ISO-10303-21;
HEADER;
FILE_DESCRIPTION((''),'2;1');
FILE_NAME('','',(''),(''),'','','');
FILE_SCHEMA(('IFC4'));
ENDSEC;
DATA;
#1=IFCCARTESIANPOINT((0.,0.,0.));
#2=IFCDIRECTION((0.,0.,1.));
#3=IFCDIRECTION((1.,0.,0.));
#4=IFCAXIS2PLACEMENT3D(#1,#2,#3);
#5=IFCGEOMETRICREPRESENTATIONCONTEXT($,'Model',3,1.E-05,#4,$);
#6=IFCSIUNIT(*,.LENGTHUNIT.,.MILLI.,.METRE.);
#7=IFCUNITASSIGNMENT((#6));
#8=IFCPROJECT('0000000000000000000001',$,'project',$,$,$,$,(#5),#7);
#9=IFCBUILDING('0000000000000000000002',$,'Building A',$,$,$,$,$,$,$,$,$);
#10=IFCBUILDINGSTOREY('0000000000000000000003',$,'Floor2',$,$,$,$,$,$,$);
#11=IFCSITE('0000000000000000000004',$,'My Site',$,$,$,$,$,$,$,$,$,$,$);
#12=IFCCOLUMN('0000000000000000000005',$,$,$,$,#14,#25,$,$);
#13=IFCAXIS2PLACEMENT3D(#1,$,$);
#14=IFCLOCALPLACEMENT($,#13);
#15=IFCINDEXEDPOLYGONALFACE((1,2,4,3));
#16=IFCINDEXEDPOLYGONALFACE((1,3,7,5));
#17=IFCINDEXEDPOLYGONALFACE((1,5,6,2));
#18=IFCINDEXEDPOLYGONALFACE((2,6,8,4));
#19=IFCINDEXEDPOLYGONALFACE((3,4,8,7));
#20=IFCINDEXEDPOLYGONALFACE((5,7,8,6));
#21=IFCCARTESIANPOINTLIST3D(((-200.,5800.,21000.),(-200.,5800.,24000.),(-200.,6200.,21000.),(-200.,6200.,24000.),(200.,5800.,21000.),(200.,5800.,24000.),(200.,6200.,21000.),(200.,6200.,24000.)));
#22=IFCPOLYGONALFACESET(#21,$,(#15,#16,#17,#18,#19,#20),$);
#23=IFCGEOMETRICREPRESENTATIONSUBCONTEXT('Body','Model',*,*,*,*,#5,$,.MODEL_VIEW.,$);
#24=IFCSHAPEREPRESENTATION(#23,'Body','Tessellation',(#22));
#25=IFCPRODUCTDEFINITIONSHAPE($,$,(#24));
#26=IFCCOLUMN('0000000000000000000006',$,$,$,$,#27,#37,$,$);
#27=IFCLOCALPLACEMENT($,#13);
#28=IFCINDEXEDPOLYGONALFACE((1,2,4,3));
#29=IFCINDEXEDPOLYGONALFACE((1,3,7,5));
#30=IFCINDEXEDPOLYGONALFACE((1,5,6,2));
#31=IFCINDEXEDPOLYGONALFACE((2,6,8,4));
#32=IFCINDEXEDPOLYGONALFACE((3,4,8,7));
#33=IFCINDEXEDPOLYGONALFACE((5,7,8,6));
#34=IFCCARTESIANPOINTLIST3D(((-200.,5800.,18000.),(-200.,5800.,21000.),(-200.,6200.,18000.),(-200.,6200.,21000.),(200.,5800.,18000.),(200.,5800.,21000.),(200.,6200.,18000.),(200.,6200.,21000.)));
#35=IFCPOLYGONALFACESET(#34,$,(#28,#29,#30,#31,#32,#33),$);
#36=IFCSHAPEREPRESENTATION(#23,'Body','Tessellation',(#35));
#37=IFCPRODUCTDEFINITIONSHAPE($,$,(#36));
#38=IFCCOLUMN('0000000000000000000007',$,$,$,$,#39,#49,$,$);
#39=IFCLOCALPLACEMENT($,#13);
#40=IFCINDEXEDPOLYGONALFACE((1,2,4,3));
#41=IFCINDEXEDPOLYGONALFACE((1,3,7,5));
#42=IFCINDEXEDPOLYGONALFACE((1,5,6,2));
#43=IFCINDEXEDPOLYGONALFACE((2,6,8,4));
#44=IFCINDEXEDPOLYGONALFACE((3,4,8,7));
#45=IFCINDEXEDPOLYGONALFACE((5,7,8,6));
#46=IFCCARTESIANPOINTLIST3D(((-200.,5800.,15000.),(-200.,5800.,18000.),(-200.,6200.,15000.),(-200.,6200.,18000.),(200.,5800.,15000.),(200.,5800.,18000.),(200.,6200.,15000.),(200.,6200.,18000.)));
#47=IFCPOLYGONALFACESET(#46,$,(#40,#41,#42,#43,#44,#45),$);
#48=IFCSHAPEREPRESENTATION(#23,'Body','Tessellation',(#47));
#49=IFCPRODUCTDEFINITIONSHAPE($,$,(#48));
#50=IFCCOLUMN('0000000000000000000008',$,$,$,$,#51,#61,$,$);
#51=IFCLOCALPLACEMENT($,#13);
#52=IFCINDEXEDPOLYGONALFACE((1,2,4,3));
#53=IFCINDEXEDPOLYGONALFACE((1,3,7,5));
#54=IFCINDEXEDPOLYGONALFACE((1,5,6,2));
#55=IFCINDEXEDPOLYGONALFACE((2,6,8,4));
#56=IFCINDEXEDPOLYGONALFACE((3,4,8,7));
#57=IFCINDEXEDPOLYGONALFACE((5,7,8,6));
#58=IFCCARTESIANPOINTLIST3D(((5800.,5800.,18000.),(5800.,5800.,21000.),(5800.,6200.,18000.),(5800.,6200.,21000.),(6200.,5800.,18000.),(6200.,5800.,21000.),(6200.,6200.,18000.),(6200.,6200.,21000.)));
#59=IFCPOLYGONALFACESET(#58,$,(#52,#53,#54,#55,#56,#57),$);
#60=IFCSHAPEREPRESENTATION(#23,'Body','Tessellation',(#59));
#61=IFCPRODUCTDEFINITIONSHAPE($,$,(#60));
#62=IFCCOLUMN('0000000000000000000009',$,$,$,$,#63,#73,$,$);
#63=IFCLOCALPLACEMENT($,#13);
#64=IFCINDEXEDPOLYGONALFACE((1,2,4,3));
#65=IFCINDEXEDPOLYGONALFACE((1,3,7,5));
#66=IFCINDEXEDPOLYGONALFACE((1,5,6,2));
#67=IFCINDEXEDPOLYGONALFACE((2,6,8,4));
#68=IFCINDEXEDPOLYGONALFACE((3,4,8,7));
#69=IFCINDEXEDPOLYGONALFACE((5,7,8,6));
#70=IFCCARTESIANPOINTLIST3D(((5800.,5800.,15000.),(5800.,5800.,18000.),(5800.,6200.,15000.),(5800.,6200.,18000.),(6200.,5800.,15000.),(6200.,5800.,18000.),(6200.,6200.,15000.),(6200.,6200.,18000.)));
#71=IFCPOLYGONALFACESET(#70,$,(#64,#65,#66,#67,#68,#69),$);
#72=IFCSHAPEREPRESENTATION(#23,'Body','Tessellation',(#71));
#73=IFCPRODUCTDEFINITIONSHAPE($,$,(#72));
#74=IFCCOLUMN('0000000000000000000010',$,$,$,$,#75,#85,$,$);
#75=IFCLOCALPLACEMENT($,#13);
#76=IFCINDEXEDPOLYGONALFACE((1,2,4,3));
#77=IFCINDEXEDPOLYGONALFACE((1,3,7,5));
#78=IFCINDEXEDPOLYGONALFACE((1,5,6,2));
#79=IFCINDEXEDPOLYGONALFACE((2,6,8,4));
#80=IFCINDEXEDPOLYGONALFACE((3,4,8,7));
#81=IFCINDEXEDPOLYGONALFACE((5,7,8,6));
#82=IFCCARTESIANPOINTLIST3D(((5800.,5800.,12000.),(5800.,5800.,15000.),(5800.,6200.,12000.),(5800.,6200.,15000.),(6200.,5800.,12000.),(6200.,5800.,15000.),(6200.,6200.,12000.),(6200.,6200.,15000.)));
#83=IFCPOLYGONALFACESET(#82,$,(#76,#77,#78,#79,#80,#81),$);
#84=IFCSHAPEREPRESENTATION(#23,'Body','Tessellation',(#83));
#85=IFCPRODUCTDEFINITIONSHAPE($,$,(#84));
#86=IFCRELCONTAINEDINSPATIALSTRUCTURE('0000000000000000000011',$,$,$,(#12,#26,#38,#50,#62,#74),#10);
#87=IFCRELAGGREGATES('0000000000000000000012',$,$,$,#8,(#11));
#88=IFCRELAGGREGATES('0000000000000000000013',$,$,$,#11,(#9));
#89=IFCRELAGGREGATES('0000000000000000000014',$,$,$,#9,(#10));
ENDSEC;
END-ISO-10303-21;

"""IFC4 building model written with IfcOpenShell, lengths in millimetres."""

from ifc_helpers import new_model, si_unit, frame, origin_with_axes, place, context, subcontext, project, spatial, line, indexed_curve, outline, extrude, element, save


model = new_model("IFC4")

# Units and contexts
model_context = context("Model", 3, precision=1e-05, world=origin_with_axes())
body_context = subcontext(model_context, "Body", "Model", "MODEL_VIEW")
ifc_project = project(units=[si_unit("LENGTHUNIT", "METRE", prefix="MILLI")], contexts=[model_context])

# Site, building, storey
site = spatial("IfcSite", under=ifc_project, Name="My Site")
building = spatial("IfcBuilding", under=site, Name="Building A")
storey = spatial("IfcBuildingStorey", under=building, Name="Floor2")

# Columns
for number, where, z_axis, x_axis in (
    (1, (0.0, 6000.0, 21000.0), (0.0, 0.0, 1.0), (1.0, 0.0, 0.0)),
    (2, (0.0, 6000.0, 18000.0), (0.0, 0.0, 1.0), (1.0, 0.0, 0.0)),
    (3, (0.0, 6000.0, 15000.0), (0.0, 0.0, 1.0), (1.0, 0.0, 0.0)),
    (4, (6000.0, 6000.0, 18000.0), (0.0, 0.0, 1.0), (1.0, 0.0, 0.0)),
    (5, (6000.0, 6000.0, 15000.0), (0.0, 0.0, 1.0), (1.0, 0.0, 0.0)),
    (6, (6000.0, 6000.0, 12000.0), (0.0, 0.0, 1.0), (1.0, 0.0, 0.0)),
):
    element("IfcColumn", number, at=place(None, frame(where, z_axis=z_axis, x_axis=x_axis)), inside=storey, context=body_context, shape_type="SweptSolid", body=[
        extrude(outline(indexed_curve([(-200.0, -200.0), (200.0, -200.0), (200.0, 200.0), (-200.0, 200.0)], segments=[line(1, 2, 3, 4, 1)])), origin_with_axes(), (0.0, 0.0, 1.0), 3000.0),
    ])

save(model, "model.ifc")
